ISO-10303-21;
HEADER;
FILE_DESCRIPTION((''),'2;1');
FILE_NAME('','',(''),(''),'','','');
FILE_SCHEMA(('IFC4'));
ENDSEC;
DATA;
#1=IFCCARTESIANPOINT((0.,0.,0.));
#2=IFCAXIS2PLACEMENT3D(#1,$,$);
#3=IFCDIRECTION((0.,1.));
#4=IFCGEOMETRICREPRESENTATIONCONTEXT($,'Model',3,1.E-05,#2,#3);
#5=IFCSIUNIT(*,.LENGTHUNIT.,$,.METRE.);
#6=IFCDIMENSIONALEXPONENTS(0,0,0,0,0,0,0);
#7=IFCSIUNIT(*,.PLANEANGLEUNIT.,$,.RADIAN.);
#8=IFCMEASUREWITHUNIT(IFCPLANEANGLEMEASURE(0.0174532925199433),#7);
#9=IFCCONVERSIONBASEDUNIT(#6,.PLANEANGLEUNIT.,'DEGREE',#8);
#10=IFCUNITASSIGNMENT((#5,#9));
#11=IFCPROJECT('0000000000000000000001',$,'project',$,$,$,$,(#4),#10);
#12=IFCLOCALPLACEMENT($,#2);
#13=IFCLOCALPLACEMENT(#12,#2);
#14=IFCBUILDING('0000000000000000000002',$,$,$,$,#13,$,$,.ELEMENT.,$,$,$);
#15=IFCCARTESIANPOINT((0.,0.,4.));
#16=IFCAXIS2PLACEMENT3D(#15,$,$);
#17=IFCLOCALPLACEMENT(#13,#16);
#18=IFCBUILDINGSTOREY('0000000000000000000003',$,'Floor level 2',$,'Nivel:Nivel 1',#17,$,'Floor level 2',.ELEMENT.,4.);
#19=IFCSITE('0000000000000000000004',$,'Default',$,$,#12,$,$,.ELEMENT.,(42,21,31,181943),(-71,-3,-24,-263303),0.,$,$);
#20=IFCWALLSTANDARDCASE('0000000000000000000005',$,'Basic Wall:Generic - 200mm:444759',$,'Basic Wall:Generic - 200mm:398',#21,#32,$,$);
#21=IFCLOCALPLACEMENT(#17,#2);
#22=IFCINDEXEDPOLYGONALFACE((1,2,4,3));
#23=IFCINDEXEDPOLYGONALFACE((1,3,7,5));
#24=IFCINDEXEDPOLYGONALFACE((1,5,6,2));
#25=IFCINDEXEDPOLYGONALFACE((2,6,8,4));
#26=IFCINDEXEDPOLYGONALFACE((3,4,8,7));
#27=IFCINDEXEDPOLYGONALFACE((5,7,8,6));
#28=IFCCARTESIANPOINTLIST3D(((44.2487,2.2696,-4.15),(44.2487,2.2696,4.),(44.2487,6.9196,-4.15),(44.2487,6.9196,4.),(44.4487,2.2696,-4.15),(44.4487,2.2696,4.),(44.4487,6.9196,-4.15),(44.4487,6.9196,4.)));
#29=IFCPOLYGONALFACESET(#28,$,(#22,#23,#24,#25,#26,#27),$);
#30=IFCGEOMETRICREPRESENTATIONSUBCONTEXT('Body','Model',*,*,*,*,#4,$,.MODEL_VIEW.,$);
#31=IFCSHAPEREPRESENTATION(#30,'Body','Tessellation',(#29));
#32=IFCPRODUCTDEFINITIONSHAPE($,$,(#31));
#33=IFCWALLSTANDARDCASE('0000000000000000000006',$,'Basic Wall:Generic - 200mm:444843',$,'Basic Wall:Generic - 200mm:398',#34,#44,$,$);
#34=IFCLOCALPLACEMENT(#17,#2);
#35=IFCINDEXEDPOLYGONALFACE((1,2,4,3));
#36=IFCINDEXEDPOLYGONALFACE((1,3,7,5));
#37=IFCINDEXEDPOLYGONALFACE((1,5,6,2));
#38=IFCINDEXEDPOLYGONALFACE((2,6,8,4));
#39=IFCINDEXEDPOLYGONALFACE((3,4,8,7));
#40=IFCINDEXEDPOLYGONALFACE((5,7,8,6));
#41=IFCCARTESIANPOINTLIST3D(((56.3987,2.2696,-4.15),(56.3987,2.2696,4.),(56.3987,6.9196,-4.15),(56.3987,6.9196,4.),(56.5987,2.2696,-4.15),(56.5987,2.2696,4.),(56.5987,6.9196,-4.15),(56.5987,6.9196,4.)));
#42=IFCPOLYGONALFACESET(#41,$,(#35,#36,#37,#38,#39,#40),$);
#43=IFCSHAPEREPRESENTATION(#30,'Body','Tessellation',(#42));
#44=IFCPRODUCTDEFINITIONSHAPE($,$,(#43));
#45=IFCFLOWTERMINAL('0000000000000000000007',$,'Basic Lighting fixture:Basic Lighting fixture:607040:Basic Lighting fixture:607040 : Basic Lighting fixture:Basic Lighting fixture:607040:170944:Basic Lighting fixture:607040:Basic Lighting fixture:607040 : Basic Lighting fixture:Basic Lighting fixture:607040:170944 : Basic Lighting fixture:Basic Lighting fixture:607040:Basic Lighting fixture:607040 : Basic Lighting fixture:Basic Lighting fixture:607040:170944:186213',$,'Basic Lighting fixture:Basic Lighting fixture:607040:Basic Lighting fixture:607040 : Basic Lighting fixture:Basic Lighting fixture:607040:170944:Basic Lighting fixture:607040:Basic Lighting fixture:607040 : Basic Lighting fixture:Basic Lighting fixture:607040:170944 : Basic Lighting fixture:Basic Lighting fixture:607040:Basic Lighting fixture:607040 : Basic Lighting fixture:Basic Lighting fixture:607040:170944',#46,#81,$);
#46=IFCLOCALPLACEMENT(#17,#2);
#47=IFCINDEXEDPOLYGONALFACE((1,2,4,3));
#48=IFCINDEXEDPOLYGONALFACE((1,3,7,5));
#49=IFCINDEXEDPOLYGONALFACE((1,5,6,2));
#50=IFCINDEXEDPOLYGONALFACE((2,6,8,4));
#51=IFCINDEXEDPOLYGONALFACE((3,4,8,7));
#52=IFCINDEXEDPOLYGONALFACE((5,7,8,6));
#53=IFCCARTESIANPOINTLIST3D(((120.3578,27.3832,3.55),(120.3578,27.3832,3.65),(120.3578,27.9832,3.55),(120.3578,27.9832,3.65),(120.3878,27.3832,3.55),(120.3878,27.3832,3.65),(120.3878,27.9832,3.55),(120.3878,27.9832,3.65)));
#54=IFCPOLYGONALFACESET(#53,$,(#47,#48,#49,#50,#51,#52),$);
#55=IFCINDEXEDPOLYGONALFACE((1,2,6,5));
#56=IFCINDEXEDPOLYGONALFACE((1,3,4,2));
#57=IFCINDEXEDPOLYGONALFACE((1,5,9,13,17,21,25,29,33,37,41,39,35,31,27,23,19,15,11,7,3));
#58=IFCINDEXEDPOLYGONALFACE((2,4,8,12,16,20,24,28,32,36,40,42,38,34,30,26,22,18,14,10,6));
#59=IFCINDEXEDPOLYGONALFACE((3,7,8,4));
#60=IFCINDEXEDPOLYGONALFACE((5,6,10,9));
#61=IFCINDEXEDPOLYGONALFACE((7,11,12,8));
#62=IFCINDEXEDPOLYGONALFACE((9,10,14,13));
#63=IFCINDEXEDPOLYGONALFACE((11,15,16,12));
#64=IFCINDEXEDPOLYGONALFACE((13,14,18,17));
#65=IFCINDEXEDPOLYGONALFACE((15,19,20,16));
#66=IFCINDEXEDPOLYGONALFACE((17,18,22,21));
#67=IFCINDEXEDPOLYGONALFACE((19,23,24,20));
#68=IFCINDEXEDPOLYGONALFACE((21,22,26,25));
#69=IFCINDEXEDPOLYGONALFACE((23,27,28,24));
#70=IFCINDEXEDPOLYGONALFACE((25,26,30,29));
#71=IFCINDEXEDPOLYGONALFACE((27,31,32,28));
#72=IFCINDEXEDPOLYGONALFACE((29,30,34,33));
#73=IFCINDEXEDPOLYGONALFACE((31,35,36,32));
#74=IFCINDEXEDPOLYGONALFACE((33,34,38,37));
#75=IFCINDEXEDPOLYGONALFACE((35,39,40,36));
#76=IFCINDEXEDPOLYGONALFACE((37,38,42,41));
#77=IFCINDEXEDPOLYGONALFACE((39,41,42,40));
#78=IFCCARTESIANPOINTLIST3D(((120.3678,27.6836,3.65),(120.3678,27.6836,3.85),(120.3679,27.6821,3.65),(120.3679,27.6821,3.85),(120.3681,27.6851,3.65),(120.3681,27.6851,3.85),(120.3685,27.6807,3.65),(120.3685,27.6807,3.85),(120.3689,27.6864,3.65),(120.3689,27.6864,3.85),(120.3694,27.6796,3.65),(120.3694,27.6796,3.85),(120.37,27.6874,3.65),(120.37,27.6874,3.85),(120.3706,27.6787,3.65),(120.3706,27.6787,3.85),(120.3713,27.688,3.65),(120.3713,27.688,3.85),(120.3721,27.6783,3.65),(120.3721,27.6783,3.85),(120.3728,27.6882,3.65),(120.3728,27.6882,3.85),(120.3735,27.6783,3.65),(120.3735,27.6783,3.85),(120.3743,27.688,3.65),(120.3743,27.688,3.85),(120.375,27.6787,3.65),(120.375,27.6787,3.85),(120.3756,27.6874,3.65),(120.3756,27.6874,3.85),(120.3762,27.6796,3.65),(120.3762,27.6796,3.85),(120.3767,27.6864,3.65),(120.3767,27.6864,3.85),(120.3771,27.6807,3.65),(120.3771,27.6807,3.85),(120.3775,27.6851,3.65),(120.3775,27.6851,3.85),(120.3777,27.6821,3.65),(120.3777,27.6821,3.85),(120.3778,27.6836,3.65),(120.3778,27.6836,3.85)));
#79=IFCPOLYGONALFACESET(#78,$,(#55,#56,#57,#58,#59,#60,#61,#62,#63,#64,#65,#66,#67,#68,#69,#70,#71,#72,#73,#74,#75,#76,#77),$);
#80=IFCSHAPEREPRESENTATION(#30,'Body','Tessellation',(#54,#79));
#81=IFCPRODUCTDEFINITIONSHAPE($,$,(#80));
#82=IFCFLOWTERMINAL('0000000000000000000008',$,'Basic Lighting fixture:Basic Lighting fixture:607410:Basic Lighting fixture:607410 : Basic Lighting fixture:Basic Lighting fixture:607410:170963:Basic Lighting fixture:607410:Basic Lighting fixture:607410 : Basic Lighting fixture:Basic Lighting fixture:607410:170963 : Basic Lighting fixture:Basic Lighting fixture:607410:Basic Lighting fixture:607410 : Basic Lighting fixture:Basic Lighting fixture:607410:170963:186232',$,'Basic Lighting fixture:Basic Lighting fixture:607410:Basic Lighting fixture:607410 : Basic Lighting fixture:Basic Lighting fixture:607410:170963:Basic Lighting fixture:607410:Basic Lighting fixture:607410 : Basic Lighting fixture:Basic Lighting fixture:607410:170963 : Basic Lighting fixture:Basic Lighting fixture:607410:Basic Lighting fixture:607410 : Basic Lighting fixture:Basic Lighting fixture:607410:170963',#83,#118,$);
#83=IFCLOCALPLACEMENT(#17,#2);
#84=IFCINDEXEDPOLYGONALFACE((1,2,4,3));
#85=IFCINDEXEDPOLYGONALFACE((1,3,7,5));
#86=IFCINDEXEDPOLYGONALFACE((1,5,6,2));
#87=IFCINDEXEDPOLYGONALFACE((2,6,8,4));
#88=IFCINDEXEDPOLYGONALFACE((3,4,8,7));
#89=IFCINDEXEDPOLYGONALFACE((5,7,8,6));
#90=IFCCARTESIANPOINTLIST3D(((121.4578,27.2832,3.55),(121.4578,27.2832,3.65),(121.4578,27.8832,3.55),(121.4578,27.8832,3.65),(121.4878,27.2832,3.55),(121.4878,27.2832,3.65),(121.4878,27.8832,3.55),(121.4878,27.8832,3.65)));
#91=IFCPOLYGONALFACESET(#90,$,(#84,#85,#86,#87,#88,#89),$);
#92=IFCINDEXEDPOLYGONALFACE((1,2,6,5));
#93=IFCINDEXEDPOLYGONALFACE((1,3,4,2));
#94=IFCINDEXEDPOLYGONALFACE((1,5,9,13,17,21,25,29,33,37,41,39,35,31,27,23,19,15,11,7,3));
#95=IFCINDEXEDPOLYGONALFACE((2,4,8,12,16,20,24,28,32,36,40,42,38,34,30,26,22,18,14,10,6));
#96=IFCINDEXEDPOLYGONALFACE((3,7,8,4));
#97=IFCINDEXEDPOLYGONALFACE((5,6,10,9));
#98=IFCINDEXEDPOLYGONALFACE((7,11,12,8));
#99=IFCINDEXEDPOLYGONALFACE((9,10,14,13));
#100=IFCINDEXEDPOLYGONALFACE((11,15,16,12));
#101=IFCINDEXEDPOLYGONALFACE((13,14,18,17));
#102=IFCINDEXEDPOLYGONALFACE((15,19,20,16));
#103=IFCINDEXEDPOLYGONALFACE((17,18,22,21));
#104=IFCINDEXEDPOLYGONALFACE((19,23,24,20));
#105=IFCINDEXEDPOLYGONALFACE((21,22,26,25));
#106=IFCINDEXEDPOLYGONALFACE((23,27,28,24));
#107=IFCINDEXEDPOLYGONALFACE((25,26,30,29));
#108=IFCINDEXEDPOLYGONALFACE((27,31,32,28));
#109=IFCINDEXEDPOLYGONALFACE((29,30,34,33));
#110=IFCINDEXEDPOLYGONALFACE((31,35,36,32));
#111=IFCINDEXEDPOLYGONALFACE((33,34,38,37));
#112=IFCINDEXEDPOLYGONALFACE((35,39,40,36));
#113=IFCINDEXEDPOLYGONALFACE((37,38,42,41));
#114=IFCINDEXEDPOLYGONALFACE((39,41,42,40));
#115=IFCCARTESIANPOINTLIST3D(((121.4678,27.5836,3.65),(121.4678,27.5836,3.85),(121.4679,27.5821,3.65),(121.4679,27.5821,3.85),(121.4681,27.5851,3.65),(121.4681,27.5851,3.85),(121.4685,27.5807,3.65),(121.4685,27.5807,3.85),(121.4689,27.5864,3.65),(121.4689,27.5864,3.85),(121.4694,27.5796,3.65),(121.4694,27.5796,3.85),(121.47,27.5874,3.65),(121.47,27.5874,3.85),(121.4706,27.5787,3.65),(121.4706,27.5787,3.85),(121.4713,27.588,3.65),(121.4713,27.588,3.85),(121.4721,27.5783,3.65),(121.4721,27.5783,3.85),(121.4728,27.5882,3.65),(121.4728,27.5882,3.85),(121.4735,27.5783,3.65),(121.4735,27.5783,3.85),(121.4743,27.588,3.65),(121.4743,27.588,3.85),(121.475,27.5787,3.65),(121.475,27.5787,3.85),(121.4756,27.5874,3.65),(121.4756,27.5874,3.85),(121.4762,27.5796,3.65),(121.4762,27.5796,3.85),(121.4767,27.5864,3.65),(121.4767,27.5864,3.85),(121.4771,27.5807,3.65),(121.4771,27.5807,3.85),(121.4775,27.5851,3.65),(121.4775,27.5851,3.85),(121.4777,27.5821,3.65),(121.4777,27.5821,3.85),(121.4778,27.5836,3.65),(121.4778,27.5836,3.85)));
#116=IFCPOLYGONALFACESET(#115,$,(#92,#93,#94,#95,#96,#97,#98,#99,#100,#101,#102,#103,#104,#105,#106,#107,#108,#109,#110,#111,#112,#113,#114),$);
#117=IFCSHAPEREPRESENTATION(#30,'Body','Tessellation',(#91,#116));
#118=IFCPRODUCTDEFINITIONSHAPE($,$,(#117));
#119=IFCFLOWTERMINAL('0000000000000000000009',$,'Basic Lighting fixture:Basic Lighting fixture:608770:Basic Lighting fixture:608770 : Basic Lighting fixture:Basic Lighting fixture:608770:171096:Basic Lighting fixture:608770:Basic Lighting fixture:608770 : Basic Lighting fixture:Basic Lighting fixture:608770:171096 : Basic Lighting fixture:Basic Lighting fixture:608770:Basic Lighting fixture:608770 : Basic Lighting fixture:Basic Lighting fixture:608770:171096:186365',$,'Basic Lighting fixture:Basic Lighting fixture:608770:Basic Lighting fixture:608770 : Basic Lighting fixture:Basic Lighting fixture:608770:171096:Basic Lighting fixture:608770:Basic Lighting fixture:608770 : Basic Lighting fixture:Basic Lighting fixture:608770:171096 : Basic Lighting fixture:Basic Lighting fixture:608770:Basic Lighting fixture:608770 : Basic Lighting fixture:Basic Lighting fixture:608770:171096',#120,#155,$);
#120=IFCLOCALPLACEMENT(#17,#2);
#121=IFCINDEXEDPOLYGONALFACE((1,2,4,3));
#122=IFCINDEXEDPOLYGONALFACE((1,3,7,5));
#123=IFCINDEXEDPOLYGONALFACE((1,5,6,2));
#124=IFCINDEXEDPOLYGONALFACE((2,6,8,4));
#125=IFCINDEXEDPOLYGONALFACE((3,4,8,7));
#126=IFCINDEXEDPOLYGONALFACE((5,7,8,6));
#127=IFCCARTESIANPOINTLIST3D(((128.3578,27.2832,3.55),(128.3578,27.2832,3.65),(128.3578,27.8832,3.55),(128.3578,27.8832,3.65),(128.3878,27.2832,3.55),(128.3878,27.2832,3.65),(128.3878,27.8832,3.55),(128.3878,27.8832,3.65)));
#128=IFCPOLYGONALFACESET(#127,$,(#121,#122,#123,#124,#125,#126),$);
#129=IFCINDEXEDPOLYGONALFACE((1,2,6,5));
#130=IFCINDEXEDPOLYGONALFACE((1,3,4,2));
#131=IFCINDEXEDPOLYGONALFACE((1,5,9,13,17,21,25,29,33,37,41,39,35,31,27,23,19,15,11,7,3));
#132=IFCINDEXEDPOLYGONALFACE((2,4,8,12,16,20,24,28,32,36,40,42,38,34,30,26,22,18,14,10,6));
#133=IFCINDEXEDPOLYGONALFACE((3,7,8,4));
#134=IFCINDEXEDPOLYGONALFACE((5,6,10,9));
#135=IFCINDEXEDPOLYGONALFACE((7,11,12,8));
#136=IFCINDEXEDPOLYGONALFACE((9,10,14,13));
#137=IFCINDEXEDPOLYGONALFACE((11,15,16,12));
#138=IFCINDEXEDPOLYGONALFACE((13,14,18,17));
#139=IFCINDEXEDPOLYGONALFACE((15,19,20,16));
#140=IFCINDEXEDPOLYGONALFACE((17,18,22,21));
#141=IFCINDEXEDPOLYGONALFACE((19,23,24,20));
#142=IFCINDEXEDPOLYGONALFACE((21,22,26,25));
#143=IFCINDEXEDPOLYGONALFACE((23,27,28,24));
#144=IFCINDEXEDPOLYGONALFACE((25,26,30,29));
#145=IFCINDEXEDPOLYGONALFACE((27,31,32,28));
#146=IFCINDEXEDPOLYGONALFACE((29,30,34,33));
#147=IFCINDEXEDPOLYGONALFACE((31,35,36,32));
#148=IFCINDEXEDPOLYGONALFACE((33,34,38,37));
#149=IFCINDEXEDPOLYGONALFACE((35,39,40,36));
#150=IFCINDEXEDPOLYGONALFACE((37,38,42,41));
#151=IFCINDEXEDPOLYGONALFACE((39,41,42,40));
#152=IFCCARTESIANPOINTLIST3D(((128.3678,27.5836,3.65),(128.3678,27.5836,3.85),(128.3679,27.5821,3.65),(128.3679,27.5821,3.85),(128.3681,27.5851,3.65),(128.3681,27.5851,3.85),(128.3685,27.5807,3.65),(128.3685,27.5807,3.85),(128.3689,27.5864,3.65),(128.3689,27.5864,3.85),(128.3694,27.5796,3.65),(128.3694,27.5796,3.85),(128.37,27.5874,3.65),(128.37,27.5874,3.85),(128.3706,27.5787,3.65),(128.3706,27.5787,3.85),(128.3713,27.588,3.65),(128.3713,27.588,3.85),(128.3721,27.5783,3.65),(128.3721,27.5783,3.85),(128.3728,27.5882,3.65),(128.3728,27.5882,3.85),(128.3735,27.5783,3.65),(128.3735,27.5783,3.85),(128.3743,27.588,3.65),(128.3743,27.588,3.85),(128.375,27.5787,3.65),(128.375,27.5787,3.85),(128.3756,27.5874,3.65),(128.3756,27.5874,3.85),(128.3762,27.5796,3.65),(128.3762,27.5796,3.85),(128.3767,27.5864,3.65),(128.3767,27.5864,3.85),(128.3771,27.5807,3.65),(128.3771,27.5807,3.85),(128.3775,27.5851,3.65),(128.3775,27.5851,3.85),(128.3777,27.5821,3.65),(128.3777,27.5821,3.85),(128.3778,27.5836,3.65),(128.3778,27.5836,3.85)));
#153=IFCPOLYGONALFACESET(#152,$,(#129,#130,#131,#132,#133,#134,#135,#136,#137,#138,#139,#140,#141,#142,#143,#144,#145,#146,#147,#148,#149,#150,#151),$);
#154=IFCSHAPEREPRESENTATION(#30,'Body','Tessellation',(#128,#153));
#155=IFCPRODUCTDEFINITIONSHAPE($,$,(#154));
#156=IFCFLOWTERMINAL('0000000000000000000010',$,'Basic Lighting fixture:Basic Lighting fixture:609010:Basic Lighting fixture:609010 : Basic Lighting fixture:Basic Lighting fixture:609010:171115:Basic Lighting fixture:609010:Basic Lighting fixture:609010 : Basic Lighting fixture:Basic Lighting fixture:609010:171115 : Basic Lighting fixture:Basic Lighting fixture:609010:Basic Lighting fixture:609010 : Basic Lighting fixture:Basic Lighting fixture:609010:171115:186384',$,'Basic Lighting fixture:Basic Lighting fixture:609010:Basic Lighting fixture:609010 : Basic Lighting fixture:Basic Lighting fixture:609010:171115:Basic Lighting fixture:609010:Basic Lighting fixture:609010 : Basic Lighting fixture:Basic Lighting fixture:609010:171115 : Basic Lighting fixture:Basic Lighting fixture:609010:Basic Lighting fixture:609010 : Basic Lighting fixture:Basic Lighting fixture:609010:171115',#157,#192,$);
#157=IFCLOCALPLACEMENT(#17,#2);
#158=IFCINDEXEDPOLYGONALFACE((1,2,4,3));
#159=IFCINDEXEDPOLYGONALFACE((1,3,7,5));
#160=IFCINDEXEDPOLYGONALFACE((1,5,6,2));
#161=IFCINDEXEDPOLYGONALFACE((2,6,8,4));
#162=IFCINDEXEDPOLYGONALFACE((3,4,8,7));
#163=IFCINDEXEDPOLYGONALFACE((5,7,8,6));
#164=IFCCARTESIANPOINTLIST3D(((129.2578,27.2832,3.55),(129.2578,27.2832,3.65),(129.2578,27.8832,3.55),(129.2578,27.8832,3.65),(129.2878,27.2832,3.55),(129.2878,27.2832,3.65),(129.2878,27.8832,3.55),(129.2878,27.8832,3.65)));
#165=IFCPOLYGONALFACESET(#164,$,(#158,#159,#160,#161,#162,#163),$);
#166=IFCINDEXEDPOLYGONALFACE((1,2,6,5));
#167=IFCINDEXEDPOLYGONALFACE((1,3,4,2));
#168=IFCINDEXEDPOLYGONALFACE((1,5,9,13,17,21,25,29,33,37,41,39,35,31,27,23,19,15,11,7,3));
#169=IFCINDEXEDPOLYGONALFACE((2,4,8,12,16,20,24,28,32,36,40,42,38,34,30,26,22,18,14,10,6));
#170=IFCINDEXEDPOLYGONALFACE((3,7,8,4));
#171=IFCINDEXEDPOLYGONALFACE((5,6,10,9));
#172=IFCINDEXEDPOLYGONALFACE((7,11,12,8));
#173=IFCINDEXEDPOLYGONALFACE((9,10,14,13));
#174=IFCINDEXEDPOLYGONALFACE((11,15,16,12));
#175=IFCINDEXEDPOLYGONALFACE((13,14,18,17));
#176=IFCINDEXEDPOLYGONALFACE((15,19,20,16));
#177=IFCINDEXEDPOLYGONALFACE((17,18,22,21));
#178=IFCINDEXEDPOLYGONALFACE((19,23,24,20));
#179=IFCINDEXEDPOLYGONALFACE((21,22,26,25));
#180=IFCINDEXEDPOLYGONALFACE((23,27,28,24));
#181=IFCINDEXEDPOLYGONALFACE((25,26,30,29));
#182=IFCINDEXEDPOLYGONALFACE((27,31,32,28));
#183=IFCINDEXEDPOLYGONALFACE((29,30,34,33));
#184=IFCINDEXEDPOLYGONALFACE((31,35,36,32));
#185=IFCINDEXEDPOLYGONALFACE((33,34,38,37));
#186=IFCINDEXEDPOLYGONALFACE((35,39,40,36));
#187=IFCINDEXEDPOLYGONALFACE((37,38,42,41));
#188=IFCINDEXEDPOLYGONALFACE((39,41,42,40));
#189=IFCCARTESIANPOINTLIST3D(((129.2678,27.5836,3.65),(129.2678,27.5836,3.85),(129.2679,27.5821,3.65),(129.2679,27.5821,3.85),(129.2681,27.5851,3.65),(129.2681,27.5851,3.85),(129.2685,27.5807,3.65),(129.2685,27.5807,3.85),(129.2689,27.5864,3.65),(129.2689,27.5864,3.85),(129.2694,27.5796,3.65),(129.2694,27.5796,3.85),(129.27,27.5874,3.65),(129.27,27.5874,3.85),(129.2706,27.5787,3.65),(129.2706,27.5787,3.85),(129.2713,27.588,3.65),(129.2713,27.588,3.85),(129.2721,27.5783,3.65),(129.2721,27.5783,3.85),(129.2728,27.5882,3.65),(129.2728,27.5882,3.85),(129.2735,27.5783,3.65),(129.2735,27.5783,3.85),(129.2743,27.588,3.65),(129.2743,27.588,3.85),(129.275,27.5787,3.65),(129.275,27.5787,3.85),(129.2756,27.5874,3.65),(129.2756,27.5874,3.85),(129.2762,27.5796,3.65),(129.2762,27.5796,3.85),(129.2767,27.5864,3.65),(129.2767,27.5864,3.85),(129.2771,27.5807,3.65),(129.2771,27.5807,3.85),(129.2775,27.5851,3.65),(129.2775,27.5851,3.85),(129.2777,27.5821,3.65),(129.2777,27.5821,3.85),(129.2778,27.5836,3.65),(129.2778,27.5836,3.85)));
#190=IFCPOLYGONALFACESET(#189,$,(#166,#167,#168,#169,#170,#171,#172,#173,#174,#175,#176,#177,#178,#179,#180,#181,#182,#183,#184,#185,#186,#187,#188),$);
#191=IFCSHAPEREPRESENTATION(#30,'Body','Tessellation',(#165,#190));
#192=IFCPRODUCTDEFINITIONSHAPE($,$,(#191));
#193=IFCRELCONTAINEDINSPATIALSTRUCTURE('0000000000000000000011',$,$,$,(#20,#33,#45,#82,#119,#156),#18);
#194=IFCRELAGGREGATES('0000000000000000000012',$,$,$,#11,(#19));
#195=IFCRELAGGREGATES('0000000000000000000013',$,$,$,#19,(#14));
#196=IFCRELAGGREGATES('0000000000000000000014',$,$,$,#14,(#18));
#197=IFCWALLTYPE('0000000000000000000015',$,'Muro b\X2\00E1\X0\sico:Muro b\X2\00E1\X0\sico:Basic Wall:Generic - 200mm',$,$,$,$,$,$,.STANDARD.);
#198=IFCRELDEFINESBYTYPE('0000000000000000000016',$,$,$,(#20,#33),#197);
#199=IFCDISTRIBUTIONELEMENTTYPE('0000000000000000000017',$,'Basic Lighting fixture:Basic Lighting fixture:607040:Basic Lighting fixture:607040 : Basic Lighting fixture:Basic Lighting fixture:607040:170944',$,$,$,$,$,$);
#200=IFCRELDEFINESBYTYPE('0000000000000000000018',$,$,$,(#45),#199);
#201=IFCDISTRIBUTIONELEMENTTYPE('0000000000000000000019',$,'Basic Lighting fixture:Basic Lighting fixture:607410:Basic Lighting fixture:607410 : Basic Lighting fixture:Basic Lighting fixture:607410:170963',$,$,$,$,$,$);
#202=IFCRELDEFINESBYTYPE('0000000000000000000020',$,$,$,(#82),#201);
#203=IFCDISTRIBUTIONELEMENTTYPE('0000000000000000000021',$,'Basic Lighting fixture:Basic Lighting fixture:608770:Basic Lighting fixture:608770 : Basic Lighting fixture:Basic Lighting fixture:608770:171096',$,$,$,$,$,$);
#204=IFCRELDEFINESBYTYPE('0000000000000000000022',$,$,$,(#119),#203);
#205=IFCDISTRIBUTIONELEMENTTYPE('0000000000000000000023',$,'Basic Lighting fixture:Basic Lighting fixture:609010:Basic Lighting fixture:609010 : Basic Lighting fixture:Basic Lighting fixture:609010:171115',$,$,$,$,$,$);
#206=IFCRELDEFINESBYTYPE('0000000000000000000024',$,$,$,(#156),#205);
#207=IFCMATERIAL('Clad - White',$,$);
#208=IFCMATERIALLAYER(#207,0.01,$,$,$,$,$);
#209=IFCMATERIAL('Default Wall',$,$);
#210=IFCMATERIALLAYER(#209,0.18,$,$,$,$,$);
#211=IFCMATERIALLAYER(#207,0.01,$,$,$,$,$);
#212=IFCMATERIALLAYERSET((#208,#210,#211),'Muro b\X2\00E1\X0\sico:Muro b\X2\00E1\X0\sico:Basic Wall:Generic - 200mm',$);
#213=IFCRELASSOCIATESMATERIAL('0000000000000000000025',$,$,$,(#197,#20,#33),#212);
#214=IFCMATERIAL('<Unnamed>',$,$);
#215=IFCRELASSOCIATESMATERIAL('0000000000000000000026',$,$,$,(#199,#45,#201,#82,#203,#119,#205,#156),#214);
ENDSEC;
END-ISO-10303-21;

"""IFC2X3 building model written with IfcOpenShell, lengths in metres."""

from ifc_helpers import new_model, entity, si_unit, converted_unit, direction, frame, frame_2d, origin, origin_2d_with_axis, place, context, subcontext, project, spatial, rectangle, circle, extrude, source, transform, mapped, material, layer, layer_set, layer_usage, type_object, type_shapes, element, save


model = new_model("IFC2X3")

# Units and contexts
model_context = context("Model", 3, precision=1e-05, world=origin(), true_north=direction((0.0, 1.0)))
body_context = subcontext(model_context, "Body", "Model", "MODEL_VIEW")
ifc_project = project(units=[si_unit("LENGTHUNIT", "METRE"), converted_unit("PLANEANGLEUNIT", "DEGREE", entity("IfcPlaneAngleMeasure", 0.0174532925199433), si_unit("PLANEANGLEUNIT", "RADIAN"), dimensions=[0, 0, 0, 0, 0, 0, 0])], contexts=[model_context])

# Site, building, storey
site_placement = place(None, origin())
site = spatial("IfcSite", under=ifc_project, at=site_placement, Name="Default", CompositionType="ELEMENT", RefLatitude=(42, 21, 31, 181943), RefLongitude=(-71, -3, -24, -263303), RefElevation=0.0)
building_placement = place(site_placement, origin())
building = spatial("IfcBuilding", under=site, at=building_placement, CompositionType="ELEMENT")
storey_placement = place(building_placement, frame((0.0, 0.0, 4.0)))
storey = spatial("IfcBuildingStorey", under=building, at=storey_placement, Name="Floor level 2", ObjectType="Nivel:Nivel 1", LongName="Floor level 2", CompositionType="ELEMENT", Elevation=4.0)

# Walls
ifc_material_1 = material(Name="Clad - White")
ifc_layer_1 = layer(ifc_material_1, 0.01)
ifc_material_2 = material(Name="Default Wall")
ifc_layer_2 = layer(ifc_material_2, 0.18)
ifc_layer_3 = layer(ifc_material_1, 0.01)
ifc_layer_set = layer_set([ifc_layer_1, ifc_layer_2, ifc_layer_3], Name="Muro básico:Muro básico:Basic Wall:Generic - 200mm")
ifc_layer_usage_1 = layer_usage(ifc_layer_set, "AXIS2", "NEGATIVE", 0.1)
wall_type = type_object("IfcWallType", Name="Muro básico:Muro básico:Basic Wall:Generic - 200mm", PredefinedType="STANDARD", material=ifc_layer_set)
wall_1_placement = place(storey_placement, frame((44.3487, 2.2696, -4.15), z_axis=(0.0, 0.0, 1.0), x_axis=(0.0, 1.0, 0.0)))
element("IfcWallStandardCase", 1, at=wall_1_placement, inside=storey, type_object=wall_type, material=ifc_layer_usage_1, Name="Basic Wall:Generic - 200mm:444759", ObjectType="Basic Wall:Generic - 200mm:398", context=body_context, shape_type="SweptSolid", body=[
    extrude(rectangle(XDim=4.65, YDim=0.2, at=frame_2d((2.325, 0.0), x_axis=(-1.0, 0.0))), origin(), (0.0, 0.0, 1.0), 8.15),
])
ifc_layer_usage_2 = layer_usage(ifc_layer_set, "AXIS2", "NEGATIVE", 0.1)
wall_2_placement = place(storey_placement, frame((56.4987, 2.2696, -4.15), z_axis=(0.0, 0.0, 1.0), x_axis=(0.0, 1.0, 0.0)))
element("IfcWallStandardCase", 2, at=wall_2_placement, inside=storey, type_object=wall_type, material=ifc_layer_usage_2, Name="Basic Wall:Generic - 200mm:444843", ObjectType="Basic Wall:Generic - 200mm:398", context=body_context, shape_type="SweptSolid", body=[
    extrude(rectangle(XDim=4.65, YDim=0.2, at=frame_2d((2.325, 0.0), x_axis=(-1.0, 0.0))), origin(), (0.0, 0.0, 1.0), 8.15),
])

# Flow terminals
ifc_material_3 = material(Name="<Unnamed>")
distribution_element_type_1 = type_object("IfcDistributionElementType", Name="Basic Lighting fixture:Basic Lighting fixture:607040:Basic Lighting fixture:607040 : Basic Lighting fixture:Basic Lighting fixture:607040:170944", material=ifc_material_3)
shared_shape_1 = source(origin(), body_context, "Body", "SweptSolid", [
    extrude(rectangle(XDim=0.6, YDim=0.03, at=frame_2d((0.0, 0.0), x_axis=(1.0, 0.0))), frame((120.3728, 27.6832, 7.55), z_axis=(0.0, 0.0, 1.0), x_axis=(0.0, 1.0, 0.0)), (0.0, 0.0, 1.0), 0.1),
    extrude(circle(Radius=0.005, at=origin_2d_with_axis()), frame((120.3728, 27.6832, 7.65), z_axis=(0.0, 0.0, 1.0), x_axis=(0.0, 1.0, 0.0)), (0.0, 0.0, 1.0), 0.2),
])
type_shapes(distribution_element_type_1, [shared_shape_1])
flow_terminal_1_placement = place(storey_placement, frame((0.0, 0.0, -4.0)))
element("IfcFlowTerminal", 3, at=flow_terminal_1_placement, inside=storey, type_object=distribution_element_type_1, material=ifc_material_3, Name="Basic Lighting fixture:Basic Lighting fixture:607040:Basic Lighting fixture:607040 : Basic Lighting fixture:Basic Lighting fixture:607040:170944:Basic Lighting fixture:607040:Basic Lighting fixture:607040 : Basic Lighting fixture:Basic Lighting fixture:607040:170944 : Basic Lighting fixture:Basic Lighting fixture:607040:Basic Lighting fixture:607040 : Basic Lighting fixture:Basic Lighting fixture:607040:170944:186213", ObjectType="Basic Lighting fixture:Basic Lighting fixture:607040:Basic Lighting fixture:607040 : Basic Lighting fixture:Basic Lighting fixture:607040:170944:Basic Lighting fixture:607040:Basic Lighting fixture:607040 : Basic Lighting fixture:Basic Lighting fixture:607040:170944 : Basic Lighting fixture:Basic Lighting fixture:607040:Basic Lighting fixture:607040 : Basic Lighting fixture:Basic Lighting fixture:607040:170944", context=body_context, shape_type="MappedRepresentation", body=[
    mapped(shared_shape_1, transform((0.0, 0.0, 0.0), scale=1.0)),
])
distribution_element_type_2 = type_object("IfcDistributionElementType", Name="Basic Lighting fixture:Basic Lighting fixture:607410:Basic Lighting fixture:607410 : Basic Lighting fixture:Basic Lighting fixture:607410:170963", material=ifc_material_3)
shared_shape_2 = source(origin(), body_context, "Body", "SweptSolid", [
    extrude(rectangle(XDim=0.6, YDim=0.03, at=frame_2d((0.0, 0.0), x_axis=(1.0, 0.0))), frame((121.4728, 27.5832, 7.55), z_axis=(0.0, 0.0, 1.0), x_axis=(0.0, 1.0, 0.0)), (0.0, 0.0, 1.0), 0.1),
    extrude(circle(Radius=0.005, at=origin_2d_with_axis()), frame((121.4728, 27.5832, 7.65), z_axis=(0.0, 0.0, 1.0), x_axis=(0.0, 1.0, 0.0)), (0.0, 0.0, 1.0), 0.2),
])
type_shapes(distribution_element_type_2, [shared_shape_2])
flow_terminal_2_placement = place(storey_placement, frame((0.0, 0.0, -4.0)))
element("IfcFlowTerminal", 4, at=flow_terminal_2_placement, inside=storey, type_object=distribution_element_type_2, material=ifc_material_3, Name="Basic Lighting fixture:Basic Lighting fixture:607410:Basic Lighting fixture:607410 : Basic Lighting fixture:Basic Lighting fixture:607410:170963:Basic Lighting fixture:607410:Basic Lighting fixture:607410 : Basic Lighting fixture:Basic Lighting fixture:607410:170963 : Basic Lighting fixture:Basic Lighting fixture:607410:Basic Lighting fixture:607410 : Basic Lighting fixture:Basic Lighting fixture:607410:170963:186232", ObjectType="Basic Lighting fixture:Basic Lighting fixture:607410:Basic Lighting fixture:607410 : Basic Lighting fixture:Basic Lighting fixture:607410:170963:Basic Lighting fixture:607410:Basic Lighting fixture:607410 : Basic Lighting fixture:Basic Lighting fixture:607410:170963 : Basic Lighting fixture:Basic Lighting fixture:607410:Basic Lighting fixture:607410 : Basic Lighting fixture:Basic Lighting fixture:607410:170963", context=body_context, shape_type="MappedRepresentation", body=[
    mapped(shared_shape_2, transform((0.0, 0.0, 0.0), scale=1.0)),
])
distribution_element_type_3 = type_object("IfcDistributionElementType", Name="Basic Lighting fixture:Basic Lighting fixture:608770:Basic Lighting fixture:608770 : Basic Lighting fixture:Basic Lighting fixture:608770:171096", material=ifc_material_3)
shared_shape_3 = source(origin(), body_context, "Body", "SweptSolid", [
    extrude(rectangle(XDim=0.6, YDim=0.03, at=frame_2d((0.0, 0.0), x_axis=(1.0, 0.0))), frame((128.3728, 27.5832, 7.55), z_axis=(0.0, 0.0, 1.0), x_axis=(0.0, 1.0, 0.0)), (0.0, 0.0, 1.0), 0.1),
    extrude(circle(Radius=0.005, at=origin_2d_with_axis()), frame((128.3728, 27.5832, 7.65), z_axis=(0.0, 0.0, 1.0), x_axis=(0.0, 1.0, 0.0)), (0.0, 0.0, 1.0), 0.2),
])
type_shapes(distribution_element_type_3, [shared_shape_3])
flow_terminal_3_placement = place(storey_placement, frame((0.0, 0.0, -4.0)))
element("IfcFlowTerminal", 5, at=flow_terminal_3_placement, inside=storey, type_object=distribution_element_type_3, material=ifc_material_3, Name="Basic Lighting fixture:Basic Lighting fixture:608770:Basic Lighting fixture:608770 : Basic Lighting fixture:Basic Lighting fixture:608770:171096:Basic Lighting fixture:608770:Basic Lighting fixture:608770 : Basic Lighting fixture:Basic Lighting fixture:608770:171096 : Basic Lighting fixture:Basic Lighting fixture:608770:Basic Lighting fixture:608770 : Basic Lighting fixture:Basic Lighting fixture:608770:171096:186365", ObjectType="Basic Lighting fixture:Basic Lighting fixture:608770:Basic Lighting fixture:608770 : Basic Lighting fixture:Basic Lighting fixture:608770:171096:Basic Lighting fixture:608770:Basic Lighting fixture:608770 : Basic Lighting fixture:Basic Lighting fixture:608770:171096 : Basic Lighting fixture:Basic Lighting fixture:608770:Basic Lighting fixture:608770 : Basic Lighting fixture:Basic Lighting fixture:608770:171096", context=body_context, shape_type="MappedRepresentation", body=[
    mapped(shared_shape_3, transform((0.0, 0.0, 0.0), scale=1.0)),
])
distribution_element_type_4 = type_object("IfcDistributionElementType", Name="Basic Lighting fixture:Basic Lighting fixture:609010:Basic Lighting fixture:609010 : Basic Lighting fixture:Basic Lighting fixture:609010:171115", material=ifc_material_3)
shared_shape_4 = source(origin(), body_context, "Body", "SweptSolid", [
    extrude(rectangle(XDim=0.6, YDim=0.03, at=frame_2d((0.0, 0.0), x_axis=(1.0, 0.0))), frame((129.2728, 27.5832, 7.55), z_axis=(0.0, 0.0, 1.0), x_axis=(0.0, 1.0, 0.0)), (0.0, 0.0, 1.0), 0.1),
    extrude(circle(Radius=0.005, at=origin_2d_with_axis()), frame((129.2728, 27.5832, 7.65), z_axis=(0.0, 0.0, 1.0), x_axis=(0.0, 1.0, 0.0)), (0.0, 0.0, 1.0), 0.2),
])
type_shapes(distribution_element_type_4, [shared_shape_4])
flow_terminal_4_placement = place(storey_placement, frame((0.0, 0.0, -4.0)))
element("IfcFlowTerminal", 6, at=flow_terminal_4_placement, inside=storey, type_object=distribution_element_type_4, material=ifc_material_3, Name="Basic Lighting fixture:Basic Lighting fixture:609010:Basic Lighting fixture:609010 : Basic Lighting fixture:Basic Lighting fixture:609010:171115:Basic Lighting fixture:609010:Basic Lighting fixture:609010 : Basic Lighting fixture:Basic Lighting fixture:609010:171115 : Basic Lighting fixture:Basic Lighting fixture:609010:Basic Lighting fixture:609010 : Basic Lighting fixture:Basic Lighting fixture:609010:171115:186384", ObjectType="Basic Lighting fixture:Basic Lighting fixture:609010:Basic Lighting fixture:609010 : Basic Lighting fixture:Basic Lighting fixture:609010:171115:Basic Lighting fixture:609010:Basic Lighting fixture:609010 : Basic Lighting fixture:Basic Lighting fixture:609010:171115 : Basic Lighting fixture:Basic Lighting fixture:609010:Basic Lighting fixture:609010 : Basic Lighting fixture:Basic Lighting fixture:609010:171115", context=body_context, shape_type="MappedRepresentation", body=[
    mapped(shared_shape_4, transform((0.0, 0.0, 0.0), scale=1.0)),
])

save(model, "model.ifc")
